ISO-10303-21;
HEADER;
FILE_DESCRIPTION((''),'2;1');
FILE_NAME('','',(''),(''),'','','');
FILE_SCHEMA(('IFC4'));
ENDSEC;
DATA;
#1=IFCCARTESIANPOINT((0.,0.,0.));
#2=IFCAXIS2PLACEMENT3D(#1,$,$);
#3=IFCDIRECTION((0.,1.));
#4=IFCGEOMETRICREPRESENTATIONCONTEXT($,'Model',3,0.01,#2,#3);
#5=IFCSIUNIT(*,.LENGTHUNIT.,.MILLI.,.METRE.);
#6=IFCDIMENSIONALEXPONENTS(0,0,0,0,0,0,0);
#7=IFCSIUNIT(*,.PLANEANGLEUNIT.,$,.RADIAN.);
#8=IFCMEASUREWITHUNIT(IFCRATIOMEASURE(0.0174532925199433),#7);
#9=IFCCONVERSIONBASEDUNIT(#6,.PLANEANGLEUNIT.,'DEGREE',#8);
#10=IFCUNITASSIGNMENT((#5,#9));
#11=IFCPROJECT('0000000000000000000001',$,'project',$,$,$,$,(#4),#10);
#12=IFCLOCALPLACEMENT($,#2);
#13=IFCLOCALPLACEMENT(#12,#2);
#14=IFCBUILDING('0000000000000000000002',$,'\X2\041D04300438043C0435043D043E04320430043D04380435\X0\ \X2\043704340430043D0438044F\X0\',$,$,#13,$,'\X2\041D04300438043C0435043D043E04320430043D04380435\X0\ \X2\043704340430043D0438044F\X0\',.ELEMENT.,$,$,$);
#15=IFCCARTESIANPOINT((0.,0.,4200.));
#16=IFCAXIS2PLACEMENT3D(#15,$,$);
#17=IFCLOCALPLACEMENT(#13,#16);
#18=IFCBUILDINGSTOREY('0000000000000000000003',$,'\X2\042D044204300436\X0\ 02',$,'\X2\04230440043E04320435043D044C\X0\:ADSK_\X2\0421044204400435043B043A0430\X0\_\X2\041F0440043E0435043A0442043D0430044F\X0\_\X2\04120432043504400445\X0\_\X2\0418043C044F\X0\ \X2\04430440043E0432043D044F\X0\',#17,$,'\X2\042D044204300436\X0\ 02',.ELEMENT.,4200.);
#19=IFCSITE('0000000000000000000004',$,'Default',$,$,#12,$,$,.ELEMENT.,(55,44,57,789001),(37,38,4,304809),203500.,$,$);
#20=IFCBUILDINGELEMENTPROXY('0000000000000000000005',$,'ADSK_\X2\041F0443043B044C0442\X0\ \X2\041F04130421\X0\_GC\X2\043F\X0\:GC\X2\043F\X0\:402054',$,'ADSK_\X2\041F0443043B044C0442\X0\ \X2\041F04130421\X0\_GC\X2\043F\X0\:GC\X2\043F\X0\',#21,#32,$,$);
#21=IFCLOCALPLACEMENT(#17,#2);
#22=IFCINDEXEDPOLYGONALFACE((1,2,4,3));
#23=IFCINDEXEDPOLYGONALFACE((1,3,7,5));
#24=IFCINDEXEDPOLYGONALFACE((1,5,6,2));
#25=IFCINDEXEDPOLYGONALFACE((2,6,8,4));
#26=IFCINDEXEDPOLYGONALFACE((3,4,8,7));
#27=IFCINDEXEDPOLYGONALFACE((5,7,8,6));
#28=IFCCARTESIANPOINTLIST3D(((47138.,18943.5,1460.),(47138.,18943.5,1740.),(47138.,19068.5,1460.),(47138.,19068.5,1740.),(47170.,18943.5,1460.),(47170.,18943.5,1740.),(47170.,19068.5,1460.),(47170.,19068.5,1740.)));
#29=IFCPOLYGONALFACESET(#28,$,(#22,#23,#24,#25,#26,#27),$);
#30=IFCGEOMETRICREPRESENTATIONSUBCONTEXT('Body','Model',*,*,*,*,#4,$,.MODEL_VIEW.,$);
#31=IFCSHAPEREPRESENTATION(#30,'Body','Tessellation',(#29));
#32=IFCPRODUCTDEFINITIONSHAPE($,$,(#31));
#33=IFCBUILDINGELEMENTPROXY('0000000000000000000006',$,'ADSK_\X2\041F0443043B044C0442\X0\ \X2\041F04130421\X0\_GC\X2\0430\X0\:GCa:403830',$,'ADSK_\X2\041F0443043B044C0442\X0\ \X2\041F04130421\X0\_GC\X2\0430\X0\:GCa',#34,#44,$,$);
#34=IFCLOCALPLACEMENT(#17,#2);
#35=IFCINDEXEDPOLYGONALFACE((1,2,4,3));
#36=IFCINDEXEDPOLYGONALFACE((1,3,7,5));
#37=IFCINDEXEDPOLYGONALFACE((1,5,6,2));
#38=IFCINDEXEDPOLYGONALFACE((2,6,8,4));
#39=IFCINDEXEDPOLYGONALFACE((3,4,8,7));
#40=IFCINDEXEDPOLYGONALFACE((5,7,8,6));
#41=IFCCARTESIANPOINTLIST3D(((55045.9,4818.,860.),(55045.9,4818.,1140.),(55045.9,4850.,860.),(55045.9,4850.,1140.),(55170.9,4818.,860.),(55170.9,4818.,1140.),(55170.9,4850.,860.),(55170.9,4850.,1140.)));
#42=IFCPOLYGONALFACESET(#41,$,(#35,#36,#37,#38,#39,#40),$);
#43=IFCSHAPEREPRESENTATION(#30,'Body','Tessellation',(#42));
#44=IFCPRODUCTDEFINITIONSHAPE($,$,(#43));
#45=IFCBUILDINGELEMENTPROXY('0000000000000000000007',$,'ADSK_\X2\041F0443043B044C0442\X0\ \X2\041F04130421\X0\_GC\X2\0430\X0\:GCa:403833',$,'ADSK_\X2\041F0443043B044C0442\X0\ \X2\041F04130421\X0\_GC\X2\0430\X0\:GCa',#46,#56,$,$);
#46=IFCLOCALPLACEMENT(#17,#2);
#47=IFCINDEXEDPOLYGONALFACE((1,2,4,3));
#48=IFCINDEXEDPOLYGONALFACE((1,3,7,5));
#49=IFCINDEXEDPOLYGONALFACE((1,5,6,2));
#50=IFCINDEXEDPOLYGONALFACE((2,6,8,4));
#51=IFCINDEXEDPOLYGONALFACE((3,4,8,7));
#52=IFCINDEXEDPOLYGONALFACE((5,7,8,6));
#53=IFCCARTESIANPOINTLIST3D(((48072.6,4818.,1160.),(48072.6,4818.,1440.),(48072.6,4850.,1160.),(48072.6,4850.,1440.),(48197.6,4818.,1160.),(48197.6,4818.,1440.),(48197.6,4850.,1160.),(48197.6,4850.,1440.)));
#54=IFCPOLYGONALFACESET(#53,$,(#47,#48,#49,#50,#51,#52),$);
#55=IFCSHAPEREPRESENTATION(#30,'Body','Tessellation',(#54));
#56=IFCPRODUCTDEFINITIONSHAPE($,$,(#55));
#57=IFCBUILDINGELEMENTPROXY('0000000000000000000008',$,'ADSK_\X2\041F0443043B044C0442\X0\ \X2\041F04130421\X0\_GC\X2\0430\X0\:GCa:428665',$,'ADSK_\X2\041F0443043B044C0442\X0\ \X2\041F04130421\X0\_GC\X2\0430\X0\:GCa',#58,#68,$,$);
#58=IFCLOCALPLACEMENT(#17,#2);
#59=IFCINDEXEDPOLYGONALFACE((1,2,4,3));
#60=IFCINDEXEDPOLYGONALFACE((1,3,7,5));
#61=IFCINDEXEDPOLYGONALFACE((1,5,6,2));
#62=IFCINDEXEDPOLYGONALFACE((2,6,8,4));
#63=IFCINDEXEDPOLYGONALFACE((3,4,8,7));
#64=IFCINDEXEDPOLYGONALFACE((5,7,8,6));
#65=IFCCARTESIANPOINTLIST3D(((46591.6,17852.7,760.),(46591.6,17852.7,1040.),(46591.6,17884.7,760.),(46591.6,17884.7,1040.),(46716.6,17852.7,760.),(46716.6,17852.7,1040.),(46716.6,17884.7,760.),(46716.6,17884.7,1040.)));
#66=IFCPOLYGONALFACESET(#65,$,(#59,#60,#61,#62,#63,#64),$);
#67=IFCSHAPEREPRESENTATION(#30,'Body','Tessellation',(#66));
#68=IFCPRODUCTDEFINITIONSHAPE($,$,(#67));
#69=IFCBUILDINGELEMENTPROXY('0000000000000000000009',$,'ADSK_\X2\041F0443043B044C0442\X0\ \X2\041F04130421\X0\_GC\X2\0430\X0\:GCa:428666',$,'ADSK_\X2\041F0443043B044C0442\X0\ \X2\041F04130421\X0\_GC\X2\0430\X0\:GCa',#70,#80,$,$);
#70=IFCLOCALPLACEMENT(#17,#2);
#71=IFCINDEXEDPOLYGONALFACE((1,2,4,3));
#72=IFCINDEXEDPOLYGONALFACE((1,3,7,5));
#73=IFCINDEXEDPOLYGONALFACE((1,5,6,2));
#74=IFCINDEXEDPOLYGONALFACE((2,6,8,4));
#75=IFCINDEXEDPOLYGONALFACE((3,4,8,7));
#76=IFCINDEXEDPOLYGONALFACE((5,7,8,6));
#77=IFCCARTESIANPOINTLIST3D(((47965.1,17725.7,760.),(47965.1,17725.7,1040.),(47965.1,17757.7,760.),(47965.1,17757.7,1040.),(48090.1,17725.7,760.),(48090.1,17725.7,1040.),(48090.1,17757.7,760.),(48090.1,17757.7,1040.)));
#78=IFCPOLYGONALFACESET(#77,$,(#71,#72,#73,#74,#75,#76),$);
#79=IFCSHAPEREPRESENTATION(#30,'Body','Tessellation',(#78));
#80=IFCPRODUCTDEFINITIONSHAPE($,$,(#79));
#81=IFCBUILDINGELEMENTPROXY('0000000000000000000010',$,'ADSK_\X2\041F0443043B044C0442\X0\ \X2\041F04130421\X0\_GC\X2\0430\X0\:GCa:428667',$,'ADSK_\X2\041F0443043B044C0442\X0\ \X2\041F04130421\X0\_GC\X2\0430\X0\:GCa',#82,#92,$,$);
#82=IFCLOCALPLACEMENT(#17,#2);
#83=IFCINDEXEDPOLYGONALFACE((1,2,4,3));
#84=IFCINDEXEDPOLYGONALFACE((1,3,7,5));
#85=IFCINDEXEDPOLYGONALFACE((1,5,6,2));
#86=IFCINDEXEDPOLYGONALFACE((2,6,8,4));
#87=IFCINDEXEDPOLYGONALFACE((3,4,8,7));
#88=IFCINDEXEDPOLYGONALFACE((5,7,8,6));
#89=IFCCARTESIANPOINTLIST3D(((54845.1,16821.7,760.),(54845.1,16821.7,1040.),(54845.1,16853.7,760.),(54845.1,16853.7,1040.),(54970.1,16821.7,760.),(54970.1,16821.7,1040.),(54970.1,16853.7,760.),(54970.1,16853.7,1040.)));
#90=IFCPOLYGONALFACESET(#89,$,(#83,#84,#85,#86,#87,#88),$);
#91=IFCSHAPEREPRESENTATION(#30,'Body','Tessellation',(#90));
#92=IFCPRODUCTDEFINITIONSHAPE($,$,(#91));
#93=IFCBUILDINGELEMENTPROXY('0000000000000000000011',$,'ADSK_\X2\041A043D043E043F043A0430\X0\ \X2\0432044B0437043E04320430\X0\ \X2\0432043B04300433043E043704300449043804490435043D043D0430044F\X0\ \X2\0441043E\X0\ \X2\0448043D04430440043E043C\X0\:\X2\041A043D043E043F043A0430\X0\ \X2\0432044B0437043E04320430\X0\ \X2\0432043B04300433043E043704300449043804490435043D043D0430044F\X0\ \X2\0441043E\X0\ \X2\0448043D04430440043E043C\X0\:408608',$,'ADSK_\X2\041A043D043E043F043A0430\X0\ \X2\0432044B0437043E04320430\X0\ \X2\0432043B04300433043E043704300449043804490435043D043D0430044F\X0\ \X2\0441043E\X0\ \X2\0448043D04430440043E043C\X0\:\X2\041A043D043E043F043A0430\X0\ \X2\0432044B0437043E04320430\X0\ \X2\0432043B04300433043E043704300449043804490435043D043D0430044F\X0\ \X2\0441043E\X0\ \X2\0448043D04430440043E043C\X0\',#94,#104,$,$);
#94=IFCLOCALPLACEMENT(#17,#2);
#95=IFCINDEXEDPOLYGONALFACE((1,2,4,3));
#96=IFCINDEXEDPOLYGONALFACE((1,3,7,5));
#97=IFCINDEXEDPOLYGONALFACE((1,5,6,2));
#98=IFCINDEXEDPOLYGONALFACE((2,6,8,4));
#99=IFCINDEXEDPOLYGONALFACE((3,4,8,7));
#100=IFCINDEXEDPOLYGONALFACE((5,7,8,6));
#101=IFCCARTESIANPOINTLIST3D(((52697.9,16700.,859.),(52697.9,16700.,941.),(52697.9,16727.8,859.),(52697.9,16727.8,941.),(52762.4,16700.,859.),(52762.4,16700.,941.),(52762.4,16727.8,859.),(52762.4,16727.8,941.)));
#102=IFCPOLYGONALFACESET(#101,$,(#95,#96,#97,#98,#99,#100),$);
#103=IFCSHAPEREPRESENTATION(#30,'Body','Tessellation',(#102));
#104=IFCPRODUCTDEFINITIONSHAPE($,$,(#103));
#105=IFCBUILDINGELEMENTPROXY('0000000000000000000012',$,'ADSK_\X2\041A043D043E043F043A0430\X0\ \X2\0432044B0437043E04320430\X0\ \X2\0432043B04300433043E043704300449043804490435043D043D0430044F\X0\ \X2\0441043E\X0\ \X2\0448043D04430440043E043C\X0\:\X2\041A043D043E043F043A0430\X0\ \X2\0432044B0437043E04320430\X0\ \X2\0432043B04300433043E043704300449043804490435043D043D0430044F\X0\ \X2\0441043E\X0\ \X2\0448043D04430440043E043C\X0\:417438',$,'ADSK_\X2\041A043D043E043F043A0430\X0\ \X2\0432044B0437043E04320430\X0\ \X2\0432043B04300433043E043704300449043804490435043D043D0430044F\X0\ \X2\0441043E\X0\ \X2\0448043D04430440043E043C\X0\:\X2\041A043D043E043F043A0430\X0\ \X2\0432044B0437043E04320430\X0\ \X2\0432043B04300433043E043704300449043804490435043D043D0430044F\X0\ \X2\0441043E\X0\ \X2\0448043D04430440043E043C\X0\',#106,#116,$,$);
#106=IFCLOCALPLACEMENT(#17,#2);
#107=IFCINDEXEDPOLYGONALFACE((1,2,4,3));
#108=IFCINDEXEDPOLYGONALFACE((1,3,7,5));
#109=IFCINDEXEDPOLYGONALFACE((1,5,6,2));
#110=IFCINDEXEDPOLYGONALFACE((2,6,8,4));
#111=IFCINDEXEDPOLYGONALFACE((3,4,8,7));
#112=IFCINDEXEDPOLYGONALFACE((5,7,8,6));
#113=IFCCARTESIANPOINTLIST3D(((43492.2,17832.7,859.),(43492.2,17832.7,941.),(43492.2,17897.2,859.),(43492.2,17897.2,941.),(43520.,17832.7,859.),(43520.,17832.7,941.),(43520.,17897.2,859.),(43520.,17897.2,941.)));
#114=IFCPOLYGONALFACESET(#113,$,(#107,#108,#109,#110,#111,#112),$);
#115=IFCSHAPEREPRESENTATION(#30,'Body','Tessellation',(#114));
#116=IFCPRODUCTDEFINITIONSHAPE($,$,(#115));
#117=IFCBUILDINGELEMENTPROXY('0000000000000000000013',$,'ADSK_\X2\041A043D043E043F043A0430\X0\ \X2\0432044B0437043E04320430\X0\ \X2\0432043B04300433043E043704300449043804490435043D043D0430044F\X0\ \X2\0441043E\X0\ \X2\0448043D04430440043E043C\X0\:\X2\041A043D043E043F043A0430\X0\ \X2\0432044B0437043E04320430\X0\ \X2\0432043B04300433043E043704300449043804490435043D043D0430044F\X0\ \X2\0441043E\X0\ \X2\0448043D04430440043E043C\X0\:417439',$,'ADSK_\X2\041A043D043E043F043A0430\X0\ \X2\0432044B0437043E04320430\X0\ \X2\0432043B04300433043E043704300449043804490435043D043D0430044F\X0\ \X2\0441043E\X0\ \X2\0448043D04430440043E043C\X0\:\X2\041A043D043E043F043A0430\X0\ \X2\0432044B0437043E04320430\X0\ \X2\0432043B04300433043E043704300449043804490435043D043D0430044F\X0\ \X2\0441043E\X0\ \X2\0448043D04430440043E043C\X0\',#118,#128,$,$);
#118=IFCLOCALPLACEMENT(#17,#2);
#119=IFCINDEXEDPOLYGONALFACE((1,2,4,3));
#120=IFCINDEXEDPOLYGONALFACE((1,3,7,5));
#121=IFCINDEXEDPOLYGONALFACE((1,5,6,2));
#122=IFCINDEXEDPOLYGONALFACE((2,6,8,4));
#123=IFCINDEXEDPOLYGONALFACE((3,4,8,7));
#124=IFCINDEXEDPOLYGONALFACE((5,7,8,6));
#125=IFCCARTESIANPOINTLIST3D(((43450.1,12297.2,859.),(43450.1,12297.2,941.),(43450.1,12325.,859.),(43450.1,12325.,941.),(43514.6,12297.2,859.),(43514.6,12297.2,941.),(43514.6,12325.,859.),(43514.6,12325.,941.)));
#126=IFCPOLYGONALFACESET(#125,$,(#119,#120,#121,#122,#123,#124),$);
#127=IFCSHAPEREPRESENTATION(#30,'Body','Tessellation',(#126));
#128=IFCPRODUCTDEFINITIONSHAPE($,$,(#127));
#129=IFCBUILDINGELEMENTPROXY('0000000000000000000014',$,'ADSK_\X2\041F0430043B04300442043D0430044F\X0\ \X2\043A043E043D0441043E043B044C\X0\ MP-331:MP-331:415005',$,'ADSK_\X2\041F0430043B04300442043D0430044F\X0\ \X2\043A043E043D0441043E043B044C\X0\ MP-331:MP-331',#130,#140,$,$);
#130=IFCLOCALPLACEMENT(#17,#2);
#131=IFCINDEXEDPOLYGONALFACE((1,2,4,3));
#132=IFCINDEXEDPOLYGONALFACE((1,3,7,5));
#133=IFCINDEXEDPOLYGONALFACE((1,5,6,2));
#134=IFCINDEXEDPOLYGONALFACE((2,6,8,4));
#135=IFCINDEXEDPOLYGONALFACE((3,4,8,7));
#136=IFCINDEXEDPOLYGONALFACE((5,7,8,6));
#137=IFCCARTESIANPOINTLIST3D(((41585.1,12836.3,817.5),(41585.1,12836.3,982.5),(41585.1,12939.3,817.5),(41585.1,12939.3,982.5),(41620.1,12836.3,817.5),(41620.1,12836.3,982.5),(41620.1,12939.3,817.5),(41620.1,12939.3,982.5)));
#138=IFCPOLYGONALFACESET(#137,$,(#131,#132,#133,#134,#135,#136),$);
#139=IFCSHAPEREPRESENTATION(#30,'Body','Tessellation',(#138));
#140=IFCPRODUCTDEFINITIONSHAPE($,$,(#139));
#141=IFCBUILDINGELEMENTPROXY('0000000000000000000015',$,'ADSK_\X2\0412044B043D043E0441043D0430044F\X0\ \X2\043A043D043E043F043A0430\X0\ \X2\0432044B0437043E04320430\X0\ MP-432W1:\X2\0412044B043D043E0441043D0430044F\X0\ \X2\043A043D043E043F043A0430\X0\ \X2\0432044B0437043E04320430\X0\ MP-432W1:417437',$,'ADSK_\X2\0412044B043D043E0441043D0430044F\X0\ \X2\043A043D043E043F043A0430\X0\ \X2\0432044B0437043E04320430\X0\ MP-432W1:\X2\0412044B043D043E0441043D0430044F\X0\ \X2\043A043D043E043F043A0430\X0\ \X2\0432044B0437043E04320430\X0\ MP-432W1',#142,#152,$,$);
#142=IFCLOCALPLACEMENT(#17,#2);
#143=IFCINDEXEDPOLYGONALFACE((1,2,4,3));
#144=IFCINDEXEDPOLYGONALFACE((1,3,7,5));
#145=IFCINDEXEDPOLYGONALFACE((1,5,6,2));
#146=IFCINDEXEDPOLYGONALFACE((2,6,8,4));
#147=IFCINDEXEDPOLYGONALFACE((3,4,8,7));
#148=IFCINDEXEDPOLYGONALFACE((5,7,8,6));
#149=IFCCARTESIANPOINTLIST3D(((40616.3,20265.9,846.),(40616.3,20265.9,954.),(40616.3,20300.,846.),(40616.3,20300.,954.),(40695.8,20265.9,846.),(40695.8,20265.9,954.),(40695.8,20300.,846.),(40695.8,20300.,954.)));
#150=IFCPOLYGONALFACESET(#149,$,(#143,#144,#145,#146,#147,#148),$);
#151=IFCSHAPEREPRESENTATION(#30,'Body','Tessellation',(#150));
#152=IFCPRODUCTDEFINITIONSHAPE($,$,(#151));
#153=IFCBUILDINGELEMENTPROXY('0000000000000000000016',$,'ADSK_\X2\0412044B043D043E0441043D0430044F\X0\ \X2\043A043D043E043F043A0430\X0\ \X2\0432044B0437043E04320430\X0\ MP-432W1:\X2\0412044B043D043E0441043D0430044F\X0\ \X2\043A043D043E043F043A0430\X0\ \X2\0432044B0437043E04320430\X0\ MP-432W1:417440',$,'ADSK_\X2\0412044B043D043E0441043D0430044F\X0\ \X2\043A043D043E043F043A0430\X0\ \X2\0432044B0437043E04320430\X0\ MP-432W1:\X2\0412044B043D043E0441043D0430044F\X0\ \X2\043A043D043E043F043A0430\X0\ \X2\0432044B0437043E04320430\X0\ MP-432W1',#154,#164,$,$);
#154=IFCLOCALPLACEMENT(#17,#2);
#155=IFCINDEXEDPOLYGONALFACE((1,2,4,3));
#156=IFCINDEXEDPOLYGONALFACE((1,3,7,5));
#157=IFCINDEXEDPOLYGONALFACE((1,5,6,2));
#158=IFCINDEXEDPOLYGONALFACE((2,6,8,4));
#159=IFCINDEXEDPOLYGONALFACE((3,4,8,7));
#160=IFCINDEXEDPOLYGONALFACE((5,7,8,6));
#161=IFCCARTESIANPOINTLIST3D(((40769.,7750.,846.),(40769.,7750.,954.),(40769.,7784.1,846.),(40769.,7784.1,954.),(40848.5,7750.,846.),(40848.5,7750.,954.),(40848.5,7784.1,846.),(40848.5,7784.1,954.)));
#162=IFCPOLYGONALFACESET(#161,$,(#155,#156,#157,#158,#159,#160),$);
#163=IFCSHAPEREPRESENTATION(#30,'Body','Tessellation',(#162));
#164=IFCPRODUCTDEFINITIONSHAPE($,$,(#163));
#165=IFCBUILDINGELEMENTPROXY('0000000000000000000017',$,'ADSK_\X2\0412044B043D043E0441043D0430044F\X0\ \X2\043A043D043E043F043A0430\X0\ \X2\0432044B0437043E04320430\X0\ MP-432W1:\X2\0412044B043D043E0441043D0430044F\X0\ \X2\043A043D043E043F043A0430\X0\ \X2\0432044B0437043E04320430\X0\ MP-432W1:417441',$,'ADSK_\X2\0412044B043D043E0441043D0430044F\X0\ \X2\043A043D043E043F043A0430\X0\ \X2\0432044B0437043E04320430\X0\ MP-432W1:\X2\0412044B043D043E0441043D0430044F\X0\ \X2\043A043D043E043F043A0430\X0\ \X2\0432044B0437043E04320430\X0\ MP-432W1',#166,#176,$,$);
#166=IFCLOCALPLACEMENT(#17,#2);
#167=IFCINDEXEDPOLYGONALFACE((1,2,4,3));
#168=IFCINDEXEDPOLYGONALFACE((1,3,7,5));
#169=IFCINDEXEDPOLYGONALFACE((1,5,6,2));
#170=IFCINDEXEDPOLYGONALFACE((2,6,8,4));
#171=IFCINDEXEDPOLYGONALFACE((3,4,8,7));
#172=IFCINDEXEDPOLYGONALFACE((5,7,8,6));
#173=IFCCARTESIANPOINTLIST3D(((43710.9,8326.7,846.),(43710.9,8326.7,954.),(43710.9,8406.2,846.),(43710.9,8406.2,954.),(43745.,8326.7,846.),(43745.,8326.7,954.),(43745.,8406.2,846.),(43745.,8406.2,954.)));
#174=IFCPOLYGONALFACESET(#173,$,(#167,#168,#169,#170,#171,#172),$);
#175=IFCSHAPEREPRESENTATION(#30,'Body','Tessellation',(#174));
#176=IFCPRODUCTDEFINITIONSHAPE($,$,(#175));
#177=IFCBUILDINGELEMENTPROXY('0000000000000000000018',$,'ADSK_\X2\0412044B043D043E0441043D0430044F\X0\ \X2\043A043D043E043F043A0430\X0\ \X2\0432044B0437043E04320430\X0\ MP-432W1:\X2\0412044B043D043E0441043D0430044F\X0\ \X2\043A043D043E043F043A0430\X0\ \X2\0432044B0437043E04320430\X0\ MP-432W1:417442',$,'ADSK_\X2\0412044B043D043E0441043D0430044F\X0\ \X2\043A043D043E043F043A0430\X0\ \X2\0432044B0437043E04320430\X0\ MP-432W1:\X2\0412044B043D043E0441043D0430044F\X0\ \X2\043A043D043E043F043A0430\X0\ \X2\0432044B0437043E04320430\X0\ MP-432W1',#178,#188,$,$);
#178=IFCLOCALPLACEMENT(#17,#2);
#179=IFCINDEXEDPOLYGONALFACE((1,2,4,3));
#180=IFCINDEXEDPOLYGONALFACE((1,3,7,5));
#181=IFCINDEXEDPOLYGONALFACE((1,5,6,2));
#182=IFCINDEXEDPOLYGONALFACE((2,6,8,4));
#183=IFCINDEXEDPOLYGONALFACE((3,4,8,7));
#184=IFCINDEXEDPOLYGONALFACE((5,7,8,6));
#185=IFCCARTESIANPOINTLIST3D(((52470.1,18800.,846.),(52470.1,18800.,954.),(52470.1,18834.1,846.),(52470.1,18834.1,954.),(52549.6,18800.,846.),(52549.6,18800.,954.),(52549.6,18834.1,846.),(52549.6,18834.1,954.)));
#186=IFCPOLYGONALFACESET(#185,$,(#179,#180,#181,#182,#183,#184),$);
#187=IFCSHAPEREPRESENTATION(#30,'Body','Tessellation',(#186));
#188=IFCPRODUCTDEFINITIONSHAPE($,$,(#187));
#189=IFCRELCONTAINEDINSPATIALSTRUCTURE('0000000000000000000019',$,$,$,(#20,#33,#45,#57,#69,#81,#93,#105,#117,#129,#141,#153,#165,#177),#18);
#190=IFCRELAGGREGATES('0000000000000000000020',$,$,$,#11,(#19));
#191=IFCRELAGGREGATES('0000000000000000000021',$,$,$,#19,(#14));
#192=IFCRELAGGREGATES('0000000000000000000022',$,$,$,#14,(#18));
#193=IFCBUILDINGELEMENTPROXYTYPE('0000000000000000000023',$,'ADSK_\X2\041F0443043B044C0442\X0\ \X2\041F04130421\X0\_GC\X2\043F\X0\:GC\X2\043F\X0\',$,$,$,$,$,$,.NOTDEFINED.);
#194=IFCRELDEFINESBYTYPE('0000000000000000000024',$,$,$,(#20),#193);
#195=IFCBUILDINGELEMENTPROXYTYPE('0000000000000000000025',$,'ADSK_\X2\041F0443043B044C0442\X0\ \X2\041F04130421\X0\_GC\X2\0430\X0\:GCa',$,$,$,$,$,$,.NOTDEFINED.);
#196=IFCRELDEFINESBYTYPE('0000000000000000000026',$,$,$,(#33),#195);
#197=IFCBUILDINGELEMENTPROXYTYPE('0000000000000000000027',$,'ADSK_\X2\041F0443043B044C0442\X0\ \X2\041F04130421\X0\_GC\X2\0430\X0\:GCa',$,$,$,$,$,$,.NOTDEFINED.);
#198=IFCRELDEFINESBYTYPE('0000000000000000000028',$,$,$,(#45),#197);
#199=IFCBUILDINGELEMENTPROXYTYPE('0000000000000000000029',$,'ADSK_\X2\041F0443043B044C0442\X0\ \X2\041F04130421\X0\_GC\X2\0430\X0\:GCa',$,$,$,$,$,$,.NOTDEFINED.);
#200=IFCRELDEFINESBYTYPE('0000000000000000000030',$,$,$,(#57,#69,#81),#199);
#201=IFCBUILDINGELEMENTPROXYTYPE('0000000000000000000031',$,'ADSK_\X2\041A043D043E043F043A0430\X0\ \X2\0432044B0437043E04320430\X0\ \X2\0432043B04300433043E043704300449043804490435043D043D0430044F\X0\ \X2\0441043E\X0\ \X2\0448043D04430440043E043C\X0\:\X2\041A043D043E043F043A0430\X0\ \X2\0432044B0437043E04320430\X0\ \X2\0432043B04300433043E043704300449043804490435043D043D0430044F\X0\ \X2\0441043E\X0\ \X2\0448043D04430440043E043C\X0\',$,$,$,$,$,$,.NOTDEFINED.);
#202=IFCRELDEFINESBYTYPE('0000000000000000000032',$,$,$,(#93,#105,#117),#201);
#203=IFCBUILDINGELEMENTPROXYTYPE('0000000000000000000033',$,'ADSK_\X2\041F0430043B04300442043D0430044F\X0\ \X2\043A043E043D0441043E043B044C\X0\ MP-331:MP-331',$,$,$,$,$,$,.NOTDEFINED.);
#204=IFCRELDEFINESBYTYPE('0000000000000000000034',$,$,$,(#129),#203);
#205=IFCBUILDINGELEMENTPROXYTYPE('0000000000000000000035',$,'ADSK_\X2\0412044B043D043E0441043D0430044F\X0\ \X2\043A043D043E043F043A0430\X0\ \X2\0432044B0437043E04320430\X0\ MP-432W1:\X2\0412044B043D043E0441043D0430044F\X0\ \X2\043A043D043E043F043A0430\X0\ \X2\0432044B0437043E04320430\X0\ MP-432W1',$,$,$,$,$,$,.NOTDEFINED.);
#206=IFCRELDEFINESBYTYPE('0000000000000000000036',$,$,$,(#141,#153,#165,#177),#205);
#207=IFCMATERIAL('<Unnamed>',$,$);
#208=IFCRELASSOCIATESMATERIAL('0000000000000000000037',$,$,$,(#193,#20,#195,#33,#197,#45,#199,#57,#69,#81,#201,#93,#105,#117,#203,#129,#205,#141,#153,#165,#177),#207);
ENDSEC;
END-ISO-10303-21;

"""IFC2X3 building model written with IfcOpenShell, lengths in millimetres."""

from ifc_helpers import new_model, entity, si_unit, converted_unit, direction, frame, origin, origin_2d_with_axis, place, context, subcontext, project, spatial, rectangle, extrude, source, transform, mapped, material, type_object, type_shapes, element, save


model = new_model("IFC2X3")

# Units and contexts
model_context = context("Model", 3, precision=0.01, world=origin(), true_north=direction((0.0, 1.0)))
body_context = subcontext(model_context, "Body", "Model", "MODEL_VIEW")
ifc_project = project(units=[si_unit("LENGTHUNIT", "METRE", prefix="MILLI"), converted_unit("PLANEANGLEUNIT", "DEGREE", entity("IfcRatioMeasure", 0.0174532925199433), si_unit("PLANEANGLEUNIT", "RADIAN"), dimensions=[0, 0, 0, 0, 0, 0, 0])], contexts=[model_context])

# Site, building, storey
site_placement = place(None, origin())
site = spatial("IfcSite", under=ifc_project, at=site_placement, Name="Default", CompositionType="ELEMENT", RefLatitude=(55, 44, 57, 789001), RefLongitude=(37, 38, 4, 304809), RefElevation=203500.0)
building_placement = place(site_placement, origin())
building = spatial("IfcBuilding", under=site, at=building_placement, Name="Наименование здания", LongName="Наименование здания", CompositionType="ELEMENT")
storey_placement = place(building_placement, frame((0.0, 0.0, 4200.0)))
storey = spatial("IfcBuildingStorey", under=building, at=storey_placement, Name="Этаж 02", ObjectType="Уровень:ADSK_Стрелка_Проектная_Вверх_Имя уровня", LongName="Этаж 02", CompositionType="ELEMENT", Elevation=4200.0)

# Building element proxies
ifc_material_1 = material(Name="<Unnamed>")
building_element_proxy_type_1 = type_object("IfcBuildingElementProxyType", Name="ADSK_Пульт ПГС_GCп:GCп", PredefinedType="NOTDEFINED", material=ifc_material_1)
shared_shape_1 = source(origin(), body_context, "Body", "SweptSolid", [
    extrude(rectangle(XDim=125.0, YDim=32.0, at=origin_2d_with_axis()), frame((0.0, 16.0, -140.0), z_axis=(0.0, 0.0, 1.0), x_axis=(-1.0, 0.0, 0.0)), (0.0, 0.0, 1.0), 280.0),
])
type_shapes(building_element_proxy_type_1, [shared_shape_1])
proxy_1_placement = place(storey_placement, frame((47138.0, 19006.0, 1600.0), z_axis=(0.0, 0.0, 1.0), x_axis=(0.0, -1.0, 0.0)))
element("IfcBuildingElementProxy", 1, at=proxy_1_placement, inside=storey, type_object=building_element_proxy_type_1, material=ifc_material_1, Name="ADSK_Пульт ПГС_GCп:GCп:402054", ObjectType="ADSK_Пульт ПГС_GCп:GCп", context=body_context, shape_type="MappedRepresentation", body=[
    mapped(shared_shape_1, transform((0.0, 0.0, 0.0), scale=1.0)),
])
building_element_proxy_type_2 = type_object("IfcBuildingElementProxyType", Name="ADSK_Пульт ПГС_GCа:GCa", PredefinedType="NOTDEFINED", material=ifc_material_1)
shared_shape_2 = source(origin(), body_context, "Body", "SweptSolid", [
    extrude(rectangle(XDim=125.0, YDim=32.0, at=origin_2d_with_axis()), frame((0.0, 16.0, -140.0), z_axis=(0.0, 0.0, 1.0), x_axis=(-1.0, 0.0, 0.0)), (0.0, 0.0, 1.0), 280.0),
])
type_shapes(building_element_proxy_type_2, [shared_shape_2])
proxy_2_placement = place(storey_placement, frame((55108.4, 4818.0, 1000.0)))
element("IfcBuildingElementProxy", 2, at=proxy_2_placement, inside=storey, type_object=building_element_proxy_type_2, material=ifc_material_1, Name="ADSK_Пульт ПГС_GCа:GCa:403830", ObjectType="ADSK_Пульт ПГС_GCа:GCa", context=body_context, shape_type="MappedRepresentation", body=[
    mapped(shared_shape_2, transform((0.0, 0.0, 0.0), scale=1.0)),
])
building_element_proxy_type_3 = type_object("IfcBuildingElementProxyType", Name="ADSK_Пульт ПГС_GCа:GCa", PredefinedType="NOTDEFINED", material=ifc_material_1)
type_shapes(building_element_proxy_type_3, [shared_shape_2])
proxy_3_placement = place(storey_placement, frame((48135.2, 4818.0, 1300.0)))
element("IfcBuildingElementProxy", 3, at=proxy_3_placement, inside=storey, type_object=building_element_proxy_type_3, material=ifc_material_1, Name="ADSK_Пульт ПГС_GCа:GCa:403833", ObjectType="ADSK_Пульт ПГС_GCа:GCa", context=body_context, shape_type="MappedRepresentation", body=[
    mapped(shared_shape_2, transform((0.0, 0.0, 0.0), scale=1.0)),
])
building_element_proxy_type_4 = type_object("IfcBuildingElementProxyType", Name="ADSK_Пульт ПГС_GCа:GCa", PredefinedType="NOTDEFINED", material=ifc_material_1)
type_shapes(building_element_proxy_type_4, [shared_shape_2])
for number, where, name in (
    (4, (46654.1, 17852.7, 900.0), "ADSK_Пульт ПГС_GCа:GCa:428665"),
    (5, (48027.6, 17725.7, 900.0), "ADSK_Пульт ПГС_GCа:GCa:428666"),
    (6, (54907.6, 16821.7, 900.0), "ADSK_Пульт ПГС_GCа:GCa:428667"),
):
    element("IfcBuildingElementProxy", number, at=place(storey_placement, frame(where)), inside=storey, type_object=building_element_proxy_type_4, material=ifc_material_1, Name=name, ObjectType="ADSK_Пульт ПГС_GCа:GCa", context=body_context, shape_type="MappedRepresentation", body=[
        mapped(shared_shape_2, transform((0.0, 0.0, 0.0), scale=1.0)),
    ])
building_element_proxy_type_5 = type_object("IfcBuildingElementProxyType", Name="ADSK_Кнопка вызова влагозащищенная со шнуром:Кнопка вызова влагозащищенная со шнуром", PredefinedType="NOTDEFINED", material=ifc_material_1)
shared_shape_3 = source(origin(), body_context, "Body", "SweptSolid", [
    extrude(rectangle(XDim=64.5, YDim=27.8, at=origin_2d_with_axis()), frame((32.2, 13.9, 0.0), z_axis=(0.0, 0.0, 1.0), x_axis=(-1.0, 0.0, 0.0)), (0.0, 0.0, 1.0), 82.0),
])
type_shapes(building_element_proxy_type_5, [shared_shape_3])
for number, where, z_axis, x_axis, name in (
    (7, (52762.4, 16727.8, 859.0), (0.0, 0.0, 1.0), (-1.0, 0.0, 0.0), "ADSK_Кнопка вызова влагозащищенная со шнуром:Кнопка вызова влагозащищенная со шнуром:408608"),
    (8, (43492.2, 17897.2, 859.0), (0.0, 0.0, 1.0), (0.0, -1.0, 0.0), "ADSK_Кнопка вызова влагозащищенная со шнуром:Кнопка вызова влагозащищенная со шнуром:417438"),
):
    element("IfcBuildingElementProxy", number, at=place(storey_placement, frame(where, z_axis=z_axis, x_axis=x_axis)), inside=storey, type_object=building_element_proxy_type_5, material=ifc_material_1, Name=name, ObjectType="ADSK_Кнопка вызова влагозащищенная со шнуром:Кнопка вызова влагозащищенная со шнуром", context=body_context, shape_type="MappedRepresentation", body=[
        mapped(shared_shape_3, transform((0.0, 0.0, 0.0), scale=1.0)),
    ])
proxy_4_placement = place(storey_placement, frame((43450.1, 12297.2, 859.0)))
element("IfcBuildingElementProxy", 9, at=proxy_4_placement, inside=storey, type_object=building_element_proxy_type_5, material=ifc_material_1, Name="ADSK_Кнопка вызова влагозащищенная со шнуром:Кнопка вызова влагозащищенная со шнуром:417439", ObjectType="ADSK_Кнопка вызова влагозащищенная со шнуром:Кнопка вызова влагозащищенная со шнуром", context=body_context, shape_type="MappedRepresentation", body=[
    mapped(shared_shape_3, transform((0.0, 0.0, 0.0), scale=1.0)),
])
building_element_proxy_type_6 = type_object("IfcBuildingElementProxyType", Name="ADSK_Палатная консоль MP-331:MP-331", PredefinedType="NOTDEFINED", material=ifc_material_1)
shared_shape_4 = source(origin(), body_context, "Body", "SweptSolid", [
    extrude(rectangle(XDim=103.0, YDim=35.0, at=origin_2d_with_axis()), frame((0.0, 14.5, -82.5), z_axis=(0.0, 0.0, 1.0), x_axis=(-1.0, 0.0, 0.0)), (0.0, 0.0, 1.0), 165.0),
])
type_shapes(building_element_proxy_type_6, [shared_shape_4])
proxy_5_placement = place(storey_placement, frame((41588.1, 12887.8, 900.0), z_axis=(0.0, 0.0, 1.0), x_axis=(0.0, -1.0, 0.0)))
element("IfcBuildingElementProxy", 10, at=proxy_5_placement, inside=storey, type_object=building_element_proxy_type_6, material=ifc_material_1, Name="ADSK_Палатная консоль MP-331:MP-331:415005", ObjectType="ADSK_Палатная консоль MP-331:MP-331", context=body_context, shape_type="MappedRepresentation", body=[
    mapped(shared_shape_4, transform((0.0, 0.0, 0.0), scale=1.0)),
])
building_element_proxy_type_7 = type_object("IfcBuildingElementProxyType", Name="ADSK_Выносная кнопка вызова MP-432W1:Выносная кнопка вызова MP-432W1", PredefinedType="NOTDEFINED", material=ifc_material_1)
shared_shape_5 = source(origin(), body_context, "Body", "SweptSolid", [
    extrude(rectangle(XDim=79.5, YDim=34.1, at=origin_2d_with_axis()), frame((0.0, 15.0, -54.0), z_axis=(0.0, 0.0, 1.0), x_axis=(-1.0, 0.0, 0.0)), (0.0, 0.0, 1.0), 108.0),
])
type_shapes(building_element_proxy_type_7, [shared_shape_5])
proxy_6_placement = place(storey_placement, frame((40656.1, 20268.0, 900.0)))
element("IfcBuildingElementProxy", 11, at=proxy_6_placement, inside=storey, type_object=building_element_proxy_type_7, material=ifc_material_1, Name="ADSK_Выносная кнопка вызова MP-432W1:Выносная кнопка вызова MP-432W1:417437", ObjectType="ADSK_Выносная кнопка вызова MP-432W1:Выносная кнопка вызова MP-432W1", context=body_context, shape_type="MappedRepresentation", body=[
    mapped(shared_shape_5, transform((0.0, 0.0, 0.0), scale=1.0)),
])
for number, where, z_axis, x_axis, name in (
    (12, (40808.8, 7782.0, 900.0), (0.0, 0.0, 1.0), (-1.0, 0.0, 0.0), "ADSK_Выносная кнопка вызова MP-432W1:Выносная кнопка вызова MP-432W1:417440"),
    (13, (43713.0, 8366.4, 900.0), (0.0, 0.0, 1.0), (0.0, -1.0, 0.0), "ADSK_Выносная кнопка вызова MP-432W1:Выносная кнопка вызова MP-432W1:417441"),
    (14, (52509.9, 18832.0, 900.0), (0.0, 0.0, 1.0), (-1.0, 0.0, 0.0), "ADSK_Выносная кнопка вызова MP-432W1:Выносная кнопка вызова MP-432W1:417442"),
):
    element("IfcBuildingElementProxy", number, at=place(storey_placement, frame(where, z_axis=z_axis, x_axis=x_axis)), inside=storey, type_object=building_element_proxy_type_7, material=ifc_material_1, Name=name, ObjectType="ADSK_Выносная кнопка вызова MP-432W1:Выносная кнопка вызова MP-432W1", context=body_context, shape_type="MappedRepresentation", body=[
        mapped(shared_shape_5, transform((0.0, 0.0, 0.0), scale=1.0)),
    ])

save(model, "model.ifc")
